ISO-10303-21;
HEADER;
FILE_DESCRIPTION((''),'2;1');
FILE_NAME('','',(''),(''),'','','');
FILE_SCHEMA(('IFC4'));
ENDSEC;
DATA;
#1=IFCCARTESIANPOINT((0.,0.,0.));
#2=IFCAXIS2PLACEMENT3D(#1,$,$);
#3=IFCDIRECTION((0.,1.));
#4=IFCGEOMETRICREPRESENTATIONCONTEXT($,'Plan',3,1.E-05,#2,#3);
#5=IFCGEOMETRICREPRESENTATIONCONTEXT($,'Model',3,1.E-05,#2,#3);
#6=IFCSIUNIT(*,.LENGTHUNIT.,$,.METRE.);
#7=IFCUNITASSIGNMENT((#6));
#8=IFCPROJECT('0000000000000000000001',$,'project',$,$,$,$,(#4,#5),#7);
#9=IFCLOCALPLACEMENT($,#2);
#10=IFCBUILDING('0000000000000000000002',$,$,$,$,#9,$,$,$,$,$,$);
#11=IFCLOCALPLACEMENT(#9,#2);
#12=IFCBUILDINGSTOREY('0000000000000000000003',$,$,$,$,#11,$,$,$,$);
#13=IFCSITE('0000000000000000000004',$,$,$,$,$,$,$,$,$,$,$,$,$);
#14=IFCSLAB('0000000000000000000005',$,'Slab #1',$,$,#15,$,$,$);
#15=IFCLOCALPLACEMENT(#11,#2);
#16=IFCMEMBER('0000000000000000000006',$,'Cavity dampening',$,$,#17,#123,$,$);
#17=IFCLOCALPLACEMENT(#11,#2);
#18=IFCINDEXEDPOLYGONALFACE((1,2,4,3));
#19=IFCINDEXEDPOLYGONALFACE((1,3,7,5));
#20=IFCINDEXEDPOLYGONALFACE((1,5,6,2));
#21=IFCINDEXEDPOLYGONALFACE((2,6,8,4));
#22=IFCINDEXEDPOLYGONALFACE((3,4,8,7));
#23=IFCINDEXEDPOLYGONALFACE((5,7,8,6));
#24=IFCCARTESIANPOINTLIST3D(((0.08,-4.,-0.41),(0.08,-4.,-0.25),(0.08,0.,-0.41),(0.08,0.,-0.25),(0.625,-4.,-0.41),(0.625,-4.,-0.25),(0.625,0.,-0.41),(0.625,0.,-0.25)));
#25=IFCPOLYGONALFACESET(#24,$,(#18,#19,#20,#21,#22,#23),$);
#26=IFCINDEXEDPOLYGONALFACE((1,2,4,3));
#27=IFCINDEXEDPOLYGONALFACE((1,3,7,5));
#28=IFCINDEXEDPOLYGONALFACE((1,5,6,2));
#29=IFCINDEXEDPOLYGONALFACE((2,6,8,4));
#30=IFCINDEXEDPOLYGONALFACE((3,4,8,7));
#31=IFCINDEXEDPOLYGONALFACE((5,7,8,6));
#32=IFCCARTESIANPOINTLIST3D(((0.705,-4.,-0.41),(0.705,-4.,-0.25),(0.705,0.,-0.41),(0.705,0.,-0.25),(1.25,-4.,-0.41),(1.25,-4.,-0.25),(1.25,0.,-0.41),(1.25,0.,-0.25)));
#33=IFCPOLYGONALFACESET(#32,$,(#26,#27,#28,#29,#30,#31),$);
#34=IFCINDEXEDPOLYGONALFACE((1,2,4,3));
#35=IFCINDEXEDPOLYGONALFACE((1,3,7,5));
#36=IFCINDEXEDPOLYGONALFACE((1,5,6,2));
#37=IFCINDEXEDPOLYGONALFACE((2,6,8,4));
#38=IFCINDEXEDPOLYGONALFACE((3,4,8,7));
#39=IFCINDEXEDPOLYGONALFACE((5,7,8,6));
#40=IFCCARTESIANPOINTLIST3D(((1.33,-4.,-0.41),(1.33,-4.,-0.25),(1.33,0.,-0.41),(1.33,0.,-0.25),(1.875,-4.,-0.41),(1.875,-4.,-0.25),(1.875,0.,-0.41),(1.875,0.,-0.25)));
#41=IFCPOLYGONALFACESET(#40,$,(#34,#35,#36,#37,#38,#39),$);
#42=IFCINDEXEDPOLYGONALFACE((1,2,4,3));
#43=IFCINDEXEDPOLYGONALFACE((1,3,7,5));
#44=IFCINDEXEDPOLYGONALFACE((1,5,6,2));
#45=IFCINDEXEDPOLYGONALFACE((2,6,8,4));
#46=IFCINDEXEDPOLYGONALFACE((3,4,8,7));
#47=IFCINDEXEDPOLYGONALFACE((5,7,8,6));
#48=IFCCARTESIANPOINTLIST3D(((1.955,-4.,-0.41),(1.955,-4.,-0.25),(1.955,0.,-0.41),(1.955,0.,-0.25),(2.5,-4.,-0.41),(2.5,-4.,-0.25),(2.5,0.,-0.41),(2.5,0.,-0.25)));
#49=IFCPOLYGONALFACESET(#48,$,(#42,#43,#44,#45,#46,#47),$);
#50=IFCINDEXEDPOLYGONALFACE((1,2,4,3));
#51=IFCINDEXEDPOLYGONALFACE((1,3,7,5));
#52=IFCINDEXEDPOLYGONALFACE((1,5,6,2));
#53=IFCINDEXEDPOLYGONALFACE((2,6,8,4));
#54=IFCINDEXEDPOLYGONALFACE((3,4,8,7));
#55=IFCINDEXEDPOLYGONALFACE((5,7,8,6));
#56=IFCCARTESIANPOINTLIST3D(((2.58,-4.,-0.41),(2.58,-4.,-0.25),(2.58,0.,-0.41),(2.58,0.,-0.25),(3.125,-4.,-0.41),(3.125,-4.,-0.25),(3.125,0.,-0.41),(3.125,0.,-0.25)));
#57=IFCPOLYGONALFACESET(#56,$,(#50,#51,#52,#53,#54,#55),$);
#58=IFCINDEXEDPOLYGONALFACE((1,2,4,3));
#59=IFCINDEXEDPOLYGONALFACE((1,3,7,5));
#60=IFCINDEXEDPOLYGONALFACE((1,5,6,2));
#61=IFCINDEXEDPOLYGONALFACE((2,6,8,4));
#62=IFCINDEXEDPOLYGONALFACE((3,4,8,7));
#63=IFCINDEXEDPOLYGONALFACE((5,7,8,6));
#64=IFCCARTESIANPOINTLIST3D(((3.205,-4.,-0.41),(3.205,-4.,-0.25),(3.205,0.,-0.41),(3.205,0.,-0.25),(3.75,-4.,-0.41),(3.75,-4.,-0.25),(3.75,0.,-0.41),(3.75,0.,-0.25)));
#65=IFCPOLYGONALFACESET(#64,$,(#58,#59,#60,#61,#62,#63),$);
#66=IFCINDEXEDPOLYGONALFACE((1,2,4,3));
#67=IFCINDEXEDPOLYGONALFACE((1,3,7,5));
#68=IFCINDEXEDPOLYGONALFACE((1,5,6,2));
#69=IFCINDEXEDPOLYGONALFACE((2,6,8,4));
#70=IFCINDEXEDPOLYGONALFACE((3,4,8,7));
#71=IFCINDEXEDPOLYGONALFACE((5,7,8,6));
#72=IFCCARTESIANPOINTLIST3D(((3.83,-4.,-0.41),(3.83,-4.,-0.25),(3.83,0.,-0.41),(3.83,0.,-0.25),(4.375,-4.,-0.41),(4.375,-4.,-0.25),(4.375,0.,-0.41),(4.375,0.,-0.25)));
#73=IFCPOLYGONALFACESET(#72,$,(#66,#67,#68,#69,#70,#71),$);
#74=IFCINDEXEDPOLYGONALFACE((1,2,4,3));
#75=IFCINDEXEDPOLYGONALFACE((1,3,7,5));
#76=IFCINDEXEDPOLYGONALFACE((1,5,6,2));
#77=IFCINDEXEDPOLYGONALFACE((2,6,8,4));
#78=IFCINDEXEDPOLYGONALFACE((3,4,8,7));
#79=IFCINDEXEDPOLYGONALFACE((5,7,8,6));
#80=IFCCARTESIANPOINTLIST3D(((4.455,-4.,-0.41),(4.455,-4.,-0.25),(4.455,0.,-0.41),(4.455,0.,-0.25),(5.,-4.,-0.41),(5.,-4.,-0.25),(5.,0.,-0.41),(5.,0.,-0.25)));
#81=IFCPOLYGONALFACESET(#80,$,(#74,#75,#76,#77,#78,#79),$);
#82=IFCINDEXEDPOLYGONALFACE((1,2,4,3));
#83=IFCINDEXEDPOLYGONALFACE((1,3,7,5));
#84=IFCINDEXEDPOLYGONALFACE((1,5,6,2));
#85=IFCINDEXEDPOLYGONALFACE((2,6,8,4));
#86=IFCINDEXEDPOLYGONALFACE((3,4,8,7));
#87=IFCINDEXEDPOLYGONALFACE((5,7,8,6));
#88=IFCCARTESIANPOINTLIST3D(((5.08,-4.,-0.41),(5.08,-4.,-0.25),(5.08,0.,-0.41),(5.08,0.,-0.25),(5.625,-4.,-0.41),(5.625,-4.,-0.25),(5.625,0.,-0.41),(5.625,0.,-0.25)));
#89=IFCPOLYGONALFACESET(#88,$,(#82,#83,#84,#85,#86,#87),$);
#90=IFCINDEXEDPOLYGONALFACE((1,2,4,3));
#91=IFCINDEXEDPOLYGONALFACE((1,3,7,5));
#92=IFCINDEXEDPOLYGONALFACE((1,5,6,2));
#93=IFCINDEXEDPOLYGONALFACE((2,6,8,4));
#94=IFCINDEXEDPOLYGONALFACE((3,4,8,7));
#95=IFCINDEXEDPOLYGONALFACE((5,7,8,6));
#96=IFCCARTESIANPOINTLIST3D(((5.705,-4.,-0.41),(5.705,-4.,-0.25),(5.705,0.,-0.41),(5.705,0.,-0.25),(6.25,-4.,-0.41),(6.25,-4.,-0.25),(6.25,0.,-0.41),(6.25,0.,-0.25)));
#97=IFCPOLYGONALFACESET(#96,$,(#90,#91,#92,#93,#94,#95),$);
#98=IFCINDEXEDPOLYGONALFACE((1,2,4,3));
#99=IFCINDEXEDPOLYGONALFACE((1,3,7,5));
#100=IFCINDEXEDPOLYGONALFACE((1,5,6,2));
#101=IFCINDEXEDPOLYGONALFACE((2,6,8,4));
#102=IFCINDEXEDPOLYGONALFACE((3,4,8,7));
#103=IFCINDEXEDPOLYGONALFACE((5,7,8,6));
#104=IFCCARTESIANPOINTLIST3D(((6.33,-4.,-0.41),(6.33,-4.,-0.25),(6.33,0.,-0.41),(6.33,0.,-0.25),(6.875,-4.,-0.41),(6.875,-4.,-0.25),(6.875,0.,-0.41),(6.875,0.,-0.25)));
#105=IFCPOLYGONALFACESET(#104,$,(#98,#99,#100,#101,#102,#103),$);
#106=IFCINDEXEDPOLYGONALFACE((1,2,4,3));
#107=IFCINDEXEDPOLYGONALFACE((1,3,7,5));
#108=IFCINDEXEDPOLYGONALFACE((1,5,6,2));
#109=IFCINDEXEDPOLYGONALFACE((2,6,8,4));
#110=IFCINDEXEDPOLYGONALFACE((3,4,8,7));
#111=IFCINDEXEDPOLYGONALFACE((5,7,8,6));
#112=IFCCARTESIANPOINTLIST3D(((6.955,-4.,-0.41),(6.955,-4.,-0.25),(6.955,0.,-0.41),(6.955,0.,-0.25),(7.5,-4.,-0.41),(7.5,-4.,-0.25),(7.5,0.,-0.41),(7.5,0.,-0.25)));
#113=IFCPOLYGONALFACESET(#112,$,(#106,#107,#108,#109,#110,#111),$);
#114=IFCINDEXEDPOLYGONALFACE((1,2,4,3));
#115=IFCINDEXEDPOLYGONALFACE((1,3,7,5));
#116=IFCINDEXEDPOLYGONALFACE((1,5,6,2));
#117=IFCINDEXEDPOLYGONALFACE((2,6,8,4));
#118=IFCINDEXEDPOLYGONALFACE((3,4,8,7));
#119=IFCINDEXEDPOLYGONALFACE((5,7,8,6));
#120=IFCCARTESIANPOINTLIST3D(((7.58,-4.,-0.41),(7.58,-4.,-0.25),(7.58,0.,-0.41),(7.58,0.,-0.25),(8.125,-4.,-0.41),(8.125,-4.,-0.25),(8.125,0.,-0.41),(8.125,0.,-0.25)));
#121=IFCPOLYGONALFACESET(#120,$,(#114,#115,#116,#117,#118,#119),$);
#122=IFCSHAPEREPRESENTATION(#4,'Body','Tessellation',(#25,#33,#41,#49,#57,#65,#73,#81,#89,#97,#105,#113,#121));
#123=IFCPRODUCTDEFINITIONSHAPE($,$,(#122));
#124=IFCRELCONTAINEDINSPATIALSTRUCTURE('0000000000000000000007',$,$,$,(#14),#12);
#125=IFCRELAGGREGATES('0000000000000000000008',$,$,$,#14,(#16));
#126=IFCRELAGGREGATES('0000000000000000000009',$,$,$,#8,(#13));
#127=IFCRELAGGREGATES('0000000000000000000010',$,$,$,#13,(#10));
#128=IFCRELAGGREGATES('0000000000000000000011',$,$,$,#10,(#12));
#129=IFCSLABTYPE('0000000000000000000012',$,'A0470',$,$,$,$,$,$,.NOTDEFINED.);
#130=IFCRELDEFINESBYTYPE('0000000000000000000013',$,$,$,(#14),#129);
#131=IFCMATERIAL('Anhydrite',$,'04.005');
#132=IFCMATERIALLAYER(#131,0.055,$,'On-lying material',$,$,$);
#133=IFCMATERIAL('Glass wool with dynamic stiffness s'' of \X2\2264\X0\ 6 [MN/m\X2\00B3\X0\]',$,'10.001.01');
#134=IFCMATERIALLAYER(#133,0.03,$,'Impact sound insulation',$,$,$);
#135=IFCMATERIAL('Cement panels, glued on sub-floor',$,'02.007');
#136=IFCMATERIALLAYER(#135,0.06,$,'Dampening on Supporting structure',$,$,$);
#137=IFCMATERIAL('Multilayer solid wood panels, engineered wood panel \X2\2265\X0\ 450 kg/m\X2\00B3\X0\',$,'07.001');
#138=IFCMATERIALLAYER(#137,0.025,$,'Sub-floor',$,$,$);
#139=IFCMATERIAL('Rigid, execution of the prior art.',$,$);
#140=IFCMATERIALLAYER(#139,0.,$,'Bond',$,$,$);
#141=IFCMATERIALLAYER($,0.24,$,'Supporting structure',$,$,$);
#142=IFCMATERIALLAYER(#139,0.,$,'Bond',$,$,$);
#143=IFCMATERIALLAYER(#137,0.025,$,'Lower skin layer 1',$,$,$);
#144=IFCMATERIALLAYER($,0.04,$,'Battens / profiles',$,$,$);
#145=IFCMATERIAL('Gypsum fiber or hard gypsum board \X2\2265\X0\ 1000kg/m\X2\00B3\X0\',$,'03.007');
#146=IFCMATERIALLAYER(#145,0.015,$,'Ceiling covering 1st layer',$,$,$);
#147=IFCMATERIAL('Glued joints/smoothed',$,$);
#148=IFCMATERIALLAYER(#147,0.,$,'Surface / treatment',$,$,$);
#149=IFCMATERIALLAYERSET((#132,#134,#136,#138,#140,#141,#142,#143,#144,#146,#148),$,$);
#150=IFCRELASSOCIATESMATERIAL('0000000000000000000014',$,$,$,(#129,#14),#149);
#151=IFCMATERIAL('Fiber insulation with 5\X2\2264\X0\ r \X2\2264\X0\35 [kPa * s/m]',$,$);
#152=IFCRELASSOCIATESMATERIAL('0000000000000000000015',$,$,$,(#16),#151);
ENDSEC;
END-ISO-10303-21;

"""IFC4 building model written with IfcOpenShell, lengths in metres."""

from ifc_helpers import new_model, si_unit, direction, frame, frame_2d, origin, place, context, project, spatial, rectangle, extrude, material, layer, layer_set, type_object, element, aggregate, save


model = new_model("IFC4")

# Units and contexts
plan_context = context("Plan", 3, precision=1e-05, world=origin(), true_north=direction((0.0, 1.0)))
model_context = context("Model", 3, precision=1e-05, world=origin(), true_north=direction((0.0, 1.0)))
ifc_project = project(units=[si_unit("LENGTHUNIT", "METRE")], contexts=[plan_context, model_context])

# Site, building, storey
site = spatial("IfcSite", under=ifc_project)
building_placement = place(None, origin())
building = spatial("IfcBuilding", under=site, at=building_placement)
storey_placement = place(building_placement, origin())
storey = spatial("IfcBuildingStorey", under=building, at=storey_placement)

# Slab, member
ifc_material_1 = material(Name="Anhydrite", Category="04.005")
ifc_layer_1 = layer(ifc_material_1, 0.055, Name="On-lying material")
ifc_material_2 = material(Name="Glass wool with dynamic stiffness s' of ≤ 6 [MN/m³]", Category="10.001.01")
ifc_layer_2 = layer(ifc_material_2, 0.03, Name="Impact sound insulation")
ifc_material_3 = material(Name="Cement panels, glued on sub-floor", Category="02.007")
ifc_layer_3 = layer(ifc_material_3, 0.06, Name="Dampening on Supporting structure")
ifc_material_4 = material(Name="Multilayer solid wood panels, engineered wood panel ≥ 450 kg/m³", Category="07.001")
ifc_layer_4 = layer(ifc_material_4, 0.025, Name="Sub-floor")
ifc_material_5 = material(Name="Rigid, execution of the prior art.")
ifc_layer_5 = layer(ifc_material_5, 0.0, Name="Bond")
ifc_layer_6 = layer(None, 0.24, Name="Supporting structure")
ifc_layer_7 = layer(ifc_material_5, 0.0, Name="Bond")
ifc_layer_8 = layer(ifc_material_4, 0.025, Name="Lower skin layer 1")
ifc_layer_9 = layer(None, 0.04, Name="Battens / profiles")
ifc_material_6 = material(Name="Gypsum fiber or hard gypsum board ≥ 1000kg/m³", Category="03.007")
ifc_layer_10 = layer(ifc_material_6, 0.015, Name="Ceiling covering 1st layer")
ifc_material_7 = material(Name="Glued joints/smoothed")
ifc_layer_11 = layer(ifc_material_7, 0.0, Name="Surface / treatment")
ifc_layer_set = layer_set([ifc_layer_1, ifc_layer_2, ifc_layer_3, ifc_layer_4, ifc_layer_5, ifc_layer_6, ifc_layer_7, ifc_layer_8, ifc_layer_9, ifc_layer_10, ifc_layer_11])
slab_type = type_object("IfcSlabType", Name="A0470", PredefinedType="NOTDEFINED", material=ifc_layer_set)
slab_placement = place(None, frame((0.0, 0.0, 0.0), z_axis=(0.0, 0.0, -1.0), x_axis=(1.0, 0.0, 0.0)))
slab = element("IfcSlab", 1, at=slab_placement, inside=storey, type_object=slab_type, material=ifc_layer_set, Name="Slab #1")
ifc_material_8 = material(Name="Fiber insulation with 5≤ r ≤35 [kPa * s/m]")
member_1_placement = place(slab_placement, origin())
member_1 = element("IfcMember", 2, at=member_1_placement, material=ifc_material_8, Name="Cavity dampening", context=plan_context, shape_type="SweptSolid", body=[
    extrude(rectangle(XDim=0.545, YDim=0.16, at=frame_2d((0.2725, 0.08), x_axis=(1.0, 0.0))), frame((0.08, 4.0, 0.25), z_axis=(0.0, -1.0, 0.0), x_axis=(1.0, 0.0, 0.0)), (0.0, 0.0, 1.0), 4.0),
    extrude(rectangle(XDim=0.545, YDim=0.16, at=frame_2d((0.2725, 0.08), x_axis=(1.0, 0.0))), frame((0.705, 4.0, 0.25), z_axis=(0.0, -1.0, 0.0), x_axis=(1.0, 0.0, 0.0)), (0.0, 0.0, 1.0), 4.0),
    extrude(rectangle(XDim=0.545, YDim=0.16, at=frame_2d((0.2725, 0.08), x_axis=(1.0, 0.0))), frame((1.33, 4.0, 0.25), z_axis=(0.0, -1.0, 0.0), x_axis=(1.0, 0.0, 0.0)), (0.0, 0.0, 1.0), 4.0),
    extrude(rectangle(XDim=0.545, YDim=0.16, at=frame_2d((0.2725, 0.08), x_axis=(1.0, 0.0))), frame((1.955, 4.0, 0.25), z_axis=(0.0, -1.0, 0.0), x_axis=(1.0, 0.0, 0.0)), (0.0, 0.0, 1.0), 4.0),
    extrude(rectangle(XDim=0.545, YDim=0.16, at=frame_2d((0.2725, 0.08), x_axis=(1.0, 0.0))), frame((2.58, 4.0, 0.25), z_axis=(0.0, -1.0, 0.0), x_axis=(1.0, 0.0, 0.0)), (0.0, 0.0, 1.0), 4.0),
    extrude(rectangle(XDim=0.545, YDim=0.16, at=frame_2d((0.2725, 0.08), x_axis=(1.0, 0.0))), frame((3.205, 4.0, 0.25), z_axis=(0.0, -1.0, 0.0), x_axis=(1.0, 0.0, 0.0)), (0.0, 0.0, 1.0), 4.0),
    extrude(rectangle(XDim=0.545, YDim=0.16, at=frame_2d((0.2725, 0.08), x_axis=(1.0, 0.0))), frame((3.83, 4.0, 0.25), z_axis=(0.0, -1.0, 0.0), x_axis=(1.0, 0.0, 0.0)), (0.0, 0.0, 1.0), 4.0),
    extrude(rectangle(XDim=0.545, YDim=0.16, at=frame_2d((0.2725, 0.08), x_axis=(1.0, 0.0))), frame((4.455, 4.0, 0.25), z_axis=(0.0, -1.0, 0.0), x_axis=(1.0, 0.0, 0.0)), (0.0, 0.0, 1.0), 4.0),
    extrude(rectangle(XDim=0.545, YDim=0.16, at=frame_2d((0.2725, 0.08), x_axis=(1.0, 0.0))), frame((5.08, 4.0, 0.25), z_axis=(0.0, -1.0, 0.0), x_axis=(1.0, 0.0, 0.0)), (0.0, 0.0, 1.0), 4.0),
    extrude(rectangle(XDim=0.545, YDim=0.16, at=frame_2d((0.2725, 0.08), x_axis=(1.0, 0.0))), frame((5.705, 4.0, 0.25), z_axis=(0.0, -1.0, 0.0), x_axis=(1.0, 0.0, 0.0)), (0.0, 0.0, 1.0), 4.0),
    extrude(rectangle(XDim=0.545, YDim=0.16, at=frame_2d((0.2725, 0.08), x_axis=(1.0, 0.0))), frame((6.33, 4.0, 0.25), z_axis=(0.0, -1.0, 0.0), x_axis=(1.0, 0.0, 0.0)), (0.0, 0.0, 1.0), 4.0),
    extrude(rectangle(XDim=0.545, YDim=0.16, at=frame_2d((0.2725, 0.08), x_axis=(1.0, 0.0))), frame((6.955, 4.0, 0.25), z_axis=(0.0, -1.0, 0.0), x_axis=(1.0, 0.0, 0.0)), (0.0, 0.0, 1.0), 4.0),
    extrude(rectangle(XDim=0.545, YDim=0.16, at=frame_2d((0.2725, 0.08), x_axis=(1.0, 0.0))), frame((7.58, 4.0, 0.25), z_axis=(0.0, -1.0, 0.0), x_axis=(1.0, 0.0, 0.0)), (0.0, 0.0, 1.0), 4.0),
])
aggregate(slab, [member_1])

save(model, "model.ifc")
